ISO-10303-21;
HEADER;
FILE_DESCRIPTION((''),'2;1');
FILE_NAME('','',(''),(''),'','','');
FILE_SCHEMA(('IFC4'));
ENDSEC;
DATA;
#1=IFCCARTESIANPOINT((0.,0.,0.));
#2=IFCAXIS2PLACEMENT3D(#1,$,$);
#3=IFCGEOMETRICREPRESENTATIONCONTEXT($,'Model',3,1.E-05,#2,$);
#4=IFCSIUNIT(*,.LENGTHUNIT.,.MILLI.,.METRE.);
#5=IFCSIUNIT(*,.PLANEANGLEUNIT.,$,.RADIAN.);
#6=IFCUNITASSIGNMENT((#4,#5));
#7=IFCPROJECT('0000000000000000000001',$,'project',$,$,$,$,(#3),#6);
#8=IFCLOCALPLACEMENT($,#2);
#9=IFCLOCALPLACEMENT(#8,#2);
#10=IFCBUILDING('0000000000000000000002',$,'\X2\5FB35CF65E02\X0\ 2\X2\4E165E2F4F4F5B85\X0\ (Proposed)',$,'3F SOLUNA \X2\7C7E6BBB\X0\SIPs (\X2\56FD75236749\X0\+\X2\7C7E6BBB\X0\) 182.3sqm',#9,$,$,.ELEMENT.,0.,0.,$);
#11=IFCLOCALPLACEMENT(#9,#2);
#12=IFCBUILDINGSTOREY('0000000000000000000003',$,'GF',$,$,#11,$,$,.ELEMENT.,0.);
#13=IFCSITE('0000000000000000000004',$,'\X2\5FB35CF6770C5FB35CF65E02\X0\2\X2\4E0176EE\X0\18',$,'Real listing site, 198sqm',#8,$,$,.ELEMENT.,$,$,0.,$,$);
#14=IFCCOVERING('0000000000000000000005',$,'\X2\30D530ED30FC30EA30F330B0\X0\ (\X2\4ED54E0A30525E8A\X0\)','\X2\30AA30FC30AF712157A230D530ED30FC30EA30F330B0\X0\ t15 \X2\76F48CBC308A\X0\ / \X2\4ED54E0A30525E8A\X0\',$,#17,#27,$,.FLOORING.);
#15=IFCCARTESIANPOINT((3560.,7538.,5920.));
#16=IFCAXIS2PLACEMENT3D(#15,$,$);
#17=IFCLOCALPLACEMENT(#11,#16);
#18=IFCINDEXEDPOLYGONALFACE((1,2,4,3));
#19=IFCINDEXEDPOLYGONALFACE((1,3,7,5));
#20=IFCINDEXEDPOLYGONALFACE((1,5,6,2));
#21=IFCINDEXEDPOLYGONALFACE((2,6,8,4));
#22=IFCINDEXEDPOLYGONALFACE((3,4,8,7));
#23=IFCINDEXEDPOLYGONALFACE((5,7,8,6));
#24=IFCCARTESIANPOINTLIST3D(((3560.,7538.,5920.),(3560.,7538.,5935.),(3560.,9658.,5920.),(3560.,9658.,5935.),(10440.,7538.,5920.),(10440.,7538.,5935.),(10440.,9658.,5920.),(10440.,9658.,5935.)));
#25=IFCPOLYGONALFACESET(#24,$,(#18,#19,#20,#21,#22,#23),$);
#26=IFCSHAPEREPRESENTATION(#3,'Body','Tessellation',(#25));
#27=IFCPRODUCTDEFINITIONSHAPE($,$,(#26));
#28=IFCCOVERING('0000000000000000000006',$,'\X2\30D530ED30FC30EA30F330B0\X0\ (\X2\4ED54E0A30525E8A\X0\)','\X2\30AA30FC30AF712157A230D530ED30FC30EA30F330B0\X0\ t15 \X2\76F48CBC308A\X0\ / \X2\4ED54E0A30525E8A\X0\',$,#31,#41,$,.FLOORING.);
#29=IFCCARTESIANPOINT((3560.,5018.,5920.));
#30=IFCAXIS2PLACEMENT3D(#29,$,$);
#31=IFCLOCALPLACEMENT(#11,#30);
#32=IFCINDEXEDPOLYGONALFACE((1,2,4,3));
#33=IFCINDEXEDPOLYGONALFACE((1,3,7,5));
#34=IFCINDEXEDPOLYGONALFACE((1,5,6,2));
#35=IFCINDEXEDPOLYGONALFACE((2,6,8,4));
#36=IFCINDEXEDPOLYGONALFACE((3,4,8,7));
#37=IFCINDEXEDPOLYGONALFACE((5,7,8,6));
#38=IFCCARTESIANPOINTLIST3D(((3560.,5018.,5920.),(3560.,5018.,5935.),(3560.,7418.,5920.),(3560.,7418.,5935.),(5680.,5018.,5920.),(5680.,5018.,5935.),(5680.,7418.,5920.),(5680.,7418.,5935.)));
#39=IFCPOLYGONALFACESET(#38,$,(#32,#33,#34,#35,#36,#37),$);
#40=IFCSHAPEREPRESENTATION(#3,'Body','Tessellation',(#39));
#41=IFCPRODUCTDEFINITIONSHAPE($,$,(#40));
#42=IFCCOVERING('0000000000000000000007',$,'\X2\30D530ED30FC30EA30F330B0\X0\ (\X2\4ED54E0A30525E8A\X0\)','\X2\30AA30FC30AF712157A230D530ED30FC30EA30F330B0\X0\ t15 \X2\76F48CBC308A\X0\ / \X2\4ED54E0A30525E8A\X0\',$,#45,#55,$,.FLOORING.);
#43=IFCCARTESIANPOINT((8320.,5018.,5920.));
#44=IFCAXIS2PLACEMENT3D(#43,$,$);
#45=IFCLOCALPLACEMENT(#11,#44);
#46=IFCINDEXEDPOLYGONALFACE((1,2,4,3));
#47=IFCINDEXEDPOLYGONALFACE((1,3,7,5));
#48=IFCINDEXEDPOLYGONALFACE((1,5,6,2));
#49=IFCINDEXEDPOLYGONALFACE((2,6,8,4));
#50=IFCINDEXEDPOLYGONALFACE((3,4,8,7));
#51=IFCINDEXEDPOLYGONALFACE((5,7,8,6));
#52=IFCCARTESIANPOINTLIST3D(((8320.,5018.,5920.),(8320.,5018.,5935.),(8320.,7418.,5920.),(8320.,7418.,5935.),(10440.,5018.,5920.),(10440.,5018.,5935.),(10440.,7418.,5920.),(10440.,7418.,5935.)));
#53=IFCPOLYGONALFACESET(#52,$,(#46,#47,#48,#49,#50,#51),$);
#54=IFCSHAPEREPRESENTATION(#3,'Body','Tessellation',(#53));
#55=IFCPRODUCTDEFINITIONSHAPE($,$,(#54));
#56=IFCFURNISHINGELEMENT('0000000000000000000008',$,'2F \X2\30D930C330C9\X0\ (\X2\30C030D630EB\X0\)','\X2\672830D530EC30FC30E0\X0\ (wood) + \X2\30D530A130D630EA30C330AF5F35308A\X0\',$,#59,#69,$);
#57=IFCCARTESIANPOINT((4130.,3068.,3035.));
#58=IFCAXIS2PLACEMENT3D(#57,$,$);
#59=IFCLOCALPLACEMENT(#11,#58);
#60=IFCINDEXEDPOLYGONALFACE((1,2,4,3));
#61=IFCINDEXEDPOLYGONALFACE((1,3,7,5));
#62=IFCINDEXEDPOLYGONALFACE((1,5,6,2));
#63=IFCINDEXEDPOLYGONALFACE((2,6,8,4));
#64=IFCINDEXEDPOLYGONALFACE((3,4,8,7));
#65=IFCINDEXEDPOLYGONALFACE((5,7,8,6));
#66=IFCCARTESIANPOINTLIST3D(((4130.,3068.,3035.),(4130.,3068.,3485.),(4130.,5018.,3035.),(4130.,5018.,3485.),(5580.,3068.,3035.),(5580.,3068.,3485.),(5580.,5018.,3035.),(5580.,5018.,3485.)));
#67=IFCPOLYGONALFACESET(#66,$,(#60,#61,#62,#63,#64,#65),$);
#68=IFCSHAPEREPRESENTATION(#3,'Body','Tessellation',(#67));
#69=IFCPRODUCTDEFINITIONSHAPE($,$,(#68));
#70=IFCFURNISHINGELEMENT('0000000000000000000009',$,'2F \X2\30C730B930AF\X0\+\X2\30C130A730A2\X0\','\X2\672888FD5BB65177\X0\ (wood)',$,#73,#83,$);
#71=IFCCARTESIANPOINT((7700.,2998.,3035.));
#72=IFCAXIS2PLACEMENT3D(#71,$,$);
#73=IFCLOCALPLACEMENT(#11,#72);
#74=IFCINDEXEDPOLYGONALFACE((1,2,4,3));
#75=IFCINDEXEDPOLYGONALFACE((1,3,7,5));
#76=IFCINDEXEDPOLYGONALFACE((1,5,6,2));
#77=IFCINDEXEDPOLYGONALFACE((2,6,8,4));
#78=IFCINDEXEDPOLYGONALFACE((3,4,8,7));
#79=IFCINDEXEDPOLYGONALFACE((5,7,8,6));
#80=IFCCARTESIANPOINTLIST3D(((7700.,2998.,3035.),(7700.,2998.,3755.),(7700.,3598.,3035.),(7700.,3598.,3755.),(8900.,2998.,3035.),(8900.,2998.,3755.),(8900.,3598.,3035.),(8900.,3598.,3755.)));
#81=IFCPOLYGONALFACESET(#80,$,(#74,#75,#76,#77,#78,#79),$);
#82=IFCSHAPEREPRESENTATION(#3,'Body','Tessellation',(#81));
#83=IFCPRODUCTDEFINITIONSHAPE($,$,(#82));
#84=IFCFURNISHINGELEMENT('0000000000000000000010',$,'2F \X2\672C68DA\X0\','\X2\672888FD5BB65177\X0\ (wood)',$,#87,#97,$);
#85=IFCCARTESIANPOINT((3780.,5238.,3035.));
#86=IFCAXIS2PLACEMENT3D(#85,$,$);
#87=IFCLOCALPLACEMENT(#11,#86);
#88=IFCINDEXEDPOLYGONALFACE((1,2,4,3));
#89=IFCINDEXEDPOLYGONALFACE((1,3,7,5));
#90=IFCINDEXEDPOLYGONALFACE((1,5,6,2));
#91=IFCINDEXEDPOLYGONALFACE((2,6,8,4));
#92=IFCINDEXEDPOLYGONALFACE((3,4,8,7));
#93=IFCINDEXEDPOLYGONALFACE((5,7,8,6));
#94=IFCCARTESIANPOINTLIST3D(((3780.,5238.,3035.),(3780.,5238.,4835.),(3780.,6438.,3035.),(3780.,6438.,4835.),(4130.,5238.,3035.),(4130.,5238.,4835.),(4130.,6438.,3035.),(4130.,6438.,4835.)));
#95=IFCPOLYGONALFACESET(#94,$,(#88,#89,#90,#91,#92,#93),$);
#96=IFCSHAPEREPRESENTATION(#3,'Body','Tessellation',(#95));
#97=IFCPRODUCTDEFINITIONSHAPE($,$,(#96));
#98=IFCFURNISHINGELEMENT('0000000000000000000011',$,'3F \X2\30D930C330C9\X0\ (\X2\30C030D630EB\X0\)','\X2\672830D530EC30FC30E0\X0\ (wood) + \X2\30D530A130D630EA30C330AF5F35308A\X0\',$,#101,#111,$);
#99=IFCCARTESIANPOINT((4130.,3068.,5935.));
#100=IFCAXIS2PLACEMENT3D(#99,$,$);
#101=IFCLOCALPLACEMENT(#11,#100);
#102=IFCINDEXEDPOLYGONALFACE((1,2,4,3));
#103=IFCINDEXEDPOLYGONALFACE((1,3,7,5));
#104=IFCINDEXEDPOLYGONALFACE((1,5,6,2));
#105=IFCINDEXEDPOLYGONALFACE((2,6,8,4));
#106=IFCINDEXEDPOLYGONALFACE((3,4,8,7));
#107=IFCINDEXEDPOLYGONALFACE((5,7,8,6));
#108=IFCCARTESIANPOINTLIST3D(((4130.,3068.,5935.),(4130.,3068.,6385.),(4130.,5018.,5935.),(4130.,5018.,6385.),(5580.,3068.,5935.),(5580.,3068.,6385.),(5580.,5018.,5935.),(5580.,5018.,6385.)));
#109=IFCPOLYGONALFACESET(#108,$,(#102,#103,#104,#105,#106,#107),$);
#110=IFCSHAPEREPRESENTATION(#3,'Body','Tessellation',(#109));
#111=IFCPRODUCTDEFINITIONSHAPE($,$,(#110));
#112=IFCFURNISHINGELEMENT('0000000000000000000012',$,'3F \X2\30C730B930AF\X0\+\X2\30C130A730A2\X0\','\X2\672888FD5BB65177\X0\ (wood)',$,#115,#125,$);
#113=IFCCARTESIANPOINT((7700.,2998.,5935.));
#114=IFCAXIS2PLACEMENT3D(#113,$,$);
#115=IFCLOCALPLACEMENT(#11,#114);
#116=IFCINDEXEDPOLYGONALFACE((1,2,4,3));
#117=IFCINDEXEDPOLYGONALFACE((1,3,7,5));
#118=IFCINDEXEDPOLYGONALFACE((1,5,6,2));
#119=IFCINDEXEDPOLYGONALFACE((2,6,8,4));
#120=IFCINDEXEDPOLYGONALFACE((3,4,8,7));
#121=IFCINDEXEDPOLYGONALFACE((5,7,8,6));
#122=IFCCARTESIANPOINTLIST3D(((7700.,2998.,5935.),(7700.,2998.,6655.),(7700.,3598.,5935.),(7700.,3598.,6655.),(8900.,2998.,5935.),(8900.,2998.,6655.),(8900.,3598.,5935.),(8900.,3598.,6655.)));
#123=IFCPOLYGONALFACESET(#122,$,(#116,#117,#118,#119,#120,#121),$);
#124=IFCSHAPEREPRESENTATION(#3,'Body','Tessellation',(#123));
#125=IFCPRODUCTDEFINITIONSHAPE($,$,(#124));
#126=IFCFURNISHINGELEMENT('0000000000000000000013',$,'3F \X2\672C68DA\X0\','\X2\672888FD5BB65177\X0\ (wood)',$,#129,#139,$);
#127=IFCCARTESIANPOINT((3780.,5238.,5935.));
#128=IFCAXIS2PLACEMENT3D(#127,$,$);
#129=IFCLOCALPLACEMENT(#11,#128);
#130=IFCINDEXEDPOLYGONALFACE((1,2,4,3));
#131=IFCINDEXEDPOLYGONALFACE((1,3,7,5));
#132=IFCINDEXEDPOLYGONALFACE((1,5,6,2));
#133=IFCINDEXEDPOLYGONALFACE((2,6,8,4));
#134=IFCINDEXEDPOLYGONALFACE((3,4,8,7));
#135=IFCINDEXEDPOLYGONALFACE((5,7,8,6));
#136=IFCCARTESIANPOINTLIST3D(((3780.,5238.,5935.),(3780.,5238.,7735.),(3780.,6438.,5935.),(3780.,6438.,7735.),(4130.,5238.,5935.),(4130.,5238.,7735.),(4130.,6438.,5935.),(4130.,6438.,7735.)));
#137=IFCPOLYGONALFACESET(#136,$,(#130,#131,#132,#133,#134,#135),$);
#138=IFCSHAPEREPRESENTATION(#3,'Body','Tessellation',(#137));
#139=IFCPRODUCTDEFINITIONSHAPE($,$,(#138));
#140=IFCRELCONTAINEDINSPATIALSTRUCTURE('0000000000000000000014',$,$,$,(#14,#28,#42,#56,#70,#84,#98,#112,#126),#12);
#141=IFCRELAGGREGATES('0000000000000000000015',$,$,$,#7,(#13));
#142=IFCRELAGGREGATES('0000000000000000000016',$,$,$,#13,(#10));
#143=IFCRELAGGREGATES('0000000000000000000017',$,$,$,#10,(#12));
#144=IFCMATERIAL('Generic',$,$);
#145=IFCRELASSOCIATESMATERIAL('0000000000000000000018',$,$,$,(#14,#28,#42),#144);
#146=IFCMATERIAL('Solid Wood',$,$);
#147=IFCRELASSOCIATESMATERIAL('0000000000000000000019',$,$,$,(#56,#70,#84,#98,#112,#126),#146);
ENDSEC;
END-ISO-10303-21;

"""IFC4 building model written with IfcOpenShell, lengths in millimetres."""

from ifc_helpers import new_model, si_unit, frame, frame_2d, origin, place, context, project, spatial, rectangle, extrude, material, element, save


model = new_model("IFC4")

# Units and contexts
model_context = context("Model", 3, precision=1e-05, world=origin())
ifc_project = project(units=[si_unit("LENGTHUNIT", "METRE", prefix="MILLI"), si_unit("PLANEANGLEUNIT", "RADIAN")], contexts=[model_context])

# Site, building, storey
site_placement = place(None, origin())
site = spatial("IfcSite", under=ifc_project, at=site_placement, Name="徳島県徳島市2丁目18", ObjectType="Real listing site, 198sqm", CompositionType="ELEMENT", RefElevation=0.0)
building_placement = place(site_placement, origin())
building = spatial("IfcBuilding", under=site, at=building_placement, Name="徳島市 2世帯住宅 (Proposed)", ObjectType="3F SOLUNA 籾殻SIPs (国産杉+籾殻) 182.3sqm", CompositionType="ELEMENT", ElevationOfRefHeight=0.0, ElevationOfTerrain=0.0)
storey_placement = place(building_placement, origin())
storey = spatial("IfcBuildingStorey", under=building, at=storey_placement, Name="GF", CompositionType="ELEMENT", Elevation=0.0)

# Shared definitions
ifc_material_1 = material(Name="Solid Wood")

# Shared definitions
ifc_material_2 = material(Name="Generic")

# Coverings
covering_1_placement = place(storey_placement, frame((3560.0, 7538.0, 5920.0)))
element("IfcCovering", 1, at=covering_1_placement, inside=storey, material=ifc_material_2, Name="フローリング (仕上げ床)", Description="オーク無垢フローリング t15 直貼り / 仕上げ床", PredefinedType="FLOORING", context=model_context, shape_type="SweptSolid", body=[
    extrude(rectangle(XDim=6880.0, YDim=2120.0, at=frame_2d((3440.0, 1060.0))), frame((3560.0, 7538.0, 5920.0)), (0.0, 0.0, 1.0), 15.0),
])
covering_2_placement = place(storey_placement, frame((3560.0, 5018.0, 5920.0)))
element("IfcCovering", 2, at=covering_2_placement, inside=storey, material=ifc_material_2, Name="フローリング (仕上げ床)", Description="オーク無垢フローリング t15 直貼り / 仕上げ床", PredefinedType="FLOORING", context=model_context, shape_type="SweptSolid", body=[
    extrude(rectangle(XDim=2120.0, YDim=2400.0, at=frame_2d((1060.0, 1200.0))), frame((3560.0, 5018.0, 5920.0)), (0.0, 0.0, 1.0), 15.0),
])
covering_3_placement = place(storey_placement, frame((8320.0, 5018.0, 5920.0)))
element("IfcCovering", 3, at=covering_3_placement, inside=storey, material=ifc_material_2, Name="フローリング (仕上げ床)", Description="オーク無垢フローリング t15 直貼り / 仕上げ床", PredefinedType="FLOORING", context=model_context, shape_type="SweptSolid", body=[
    extrude(rectangle(XDim=2120.0, YDim=2400.0, at=frame_2d((1060.0, 1200.0))), frame((8320.0, 5018.0, 5920.0)), (0.0, 0.0, 1.0), 15.0),
])

# Furnishing elements
furnishing_1_placement = place(storey_placement, frame((4130.0, 3068.0, 3035.0)))
element("IfcFurnishingElement", 4, at=furnishing_1_placement, inside=storey, material=ifc_material_1, Name="2F ベッド (ダブル)", Description="木フレーム (wood) + ファブリック張り", context=model_context, shape_type="SweptSolid", body=[
    extrude(rectangle(XDim=1450.0, YDim=1950.0, at=frame_2d((725.0, 975.0))), frame((4130.0, 3068.0, 3035.0)), (0.0, 0.0, 1.0), 450.0),
])
furnishing_2_placement = place(storey_placement, frame((7700.0, 2998.0, 3035.0)))
element("IfcFurnishingElement", 5, at=furnishing_2_placement, inside=storey, material=ifc_material_1, Name="2F デスク+チェア", Description="木製家具 (wood)", context=model_context, shape_type="SweptSolid", body=[
    extrude(rectangle(XDim=1200.0, YDim=600.0, at=frame_2d((600.0, 300.0))), frame((7700.0, 2998.0, 3035.0)), (0.0, 0.0, 1.0), 720.0),
])
furnishing_3_placement = place(storey_placement, frame((3780.0, 5238.0, 3035.0)))
element("IfcFurnishingElement", 6, at=furnishing_3_placement, inside=storey, material=ifc_material_1, Name="2F 本棚", Description="木製家具 (wood)", context=model_context, shape_type="SweptSolid", body=[
    extrude(rectangle(XDim=350.0, YDim=1200.0, at=frame_2d((175.0, 600.0))), frame((3780.0, 5238.0, 3035.0)), (0.0, 0.0, 1.0), 1800.0),
])
furnishing_4_placement = place(storey_placement, frame((4130.0, 3068.0, 5935.0)))
element("IfcFurnishingElement", 7, at=furnishing_4_placement, inside=storey, material=ifc_material_1, Name="3F ベッド (ダブル)", Description="木フレーム (wood) + ファブリック張り", context=model_context, shape_type="SweptSolid", body=[
    extrude(rectangle(XDim=1450.0, YDim=1950.0, at=frame_2d((725.0, 975.0))), frame((4130.0, 3068.0, 5935.0)), (0.0, 0.0, 1.0), 450.0),
])
furnishing_5_placement = place(storey_placement, frame((7700.0, 2998.0, 5935.0)))
element("IfcFurnishingElement", 8, at=furnishing_5_placement, inside=storey, material=ifc_material_1, Name="3F デスク+チェア", Description="木製家具 (wood)", context=model_context, shape_type="SweptSolid", body=[
    extrude(rectangle(XDim=1200.0, YDim=600.0, at=frame_2d((600.0, 300.0))), frame((7700.0, 2998.0, 5935.0)), (0.0, 0.0, 1.0), 720.0),
])
furnishing_6_placement = place(storey_placement, frame((3780.0, 5238.0, 5935.0)))
element("IfcFurnishingElement", 9, at=furnishing_6_placement, inside=storey, material=ifc_material_1, Name="3F 本棚", Description="木製家具 (wood)", context=model_context, shape_type="SweptSolid", body=[
    extrude(rectangle(XDim=350.0, YDim=1200.0, at=frame_2d((175.0, 600.0))), frame((3780.0, 5238.0, 5935.0)), (0.0, 0.0, 1.0), 1800.0),
])

save(model, "model.ifc")
